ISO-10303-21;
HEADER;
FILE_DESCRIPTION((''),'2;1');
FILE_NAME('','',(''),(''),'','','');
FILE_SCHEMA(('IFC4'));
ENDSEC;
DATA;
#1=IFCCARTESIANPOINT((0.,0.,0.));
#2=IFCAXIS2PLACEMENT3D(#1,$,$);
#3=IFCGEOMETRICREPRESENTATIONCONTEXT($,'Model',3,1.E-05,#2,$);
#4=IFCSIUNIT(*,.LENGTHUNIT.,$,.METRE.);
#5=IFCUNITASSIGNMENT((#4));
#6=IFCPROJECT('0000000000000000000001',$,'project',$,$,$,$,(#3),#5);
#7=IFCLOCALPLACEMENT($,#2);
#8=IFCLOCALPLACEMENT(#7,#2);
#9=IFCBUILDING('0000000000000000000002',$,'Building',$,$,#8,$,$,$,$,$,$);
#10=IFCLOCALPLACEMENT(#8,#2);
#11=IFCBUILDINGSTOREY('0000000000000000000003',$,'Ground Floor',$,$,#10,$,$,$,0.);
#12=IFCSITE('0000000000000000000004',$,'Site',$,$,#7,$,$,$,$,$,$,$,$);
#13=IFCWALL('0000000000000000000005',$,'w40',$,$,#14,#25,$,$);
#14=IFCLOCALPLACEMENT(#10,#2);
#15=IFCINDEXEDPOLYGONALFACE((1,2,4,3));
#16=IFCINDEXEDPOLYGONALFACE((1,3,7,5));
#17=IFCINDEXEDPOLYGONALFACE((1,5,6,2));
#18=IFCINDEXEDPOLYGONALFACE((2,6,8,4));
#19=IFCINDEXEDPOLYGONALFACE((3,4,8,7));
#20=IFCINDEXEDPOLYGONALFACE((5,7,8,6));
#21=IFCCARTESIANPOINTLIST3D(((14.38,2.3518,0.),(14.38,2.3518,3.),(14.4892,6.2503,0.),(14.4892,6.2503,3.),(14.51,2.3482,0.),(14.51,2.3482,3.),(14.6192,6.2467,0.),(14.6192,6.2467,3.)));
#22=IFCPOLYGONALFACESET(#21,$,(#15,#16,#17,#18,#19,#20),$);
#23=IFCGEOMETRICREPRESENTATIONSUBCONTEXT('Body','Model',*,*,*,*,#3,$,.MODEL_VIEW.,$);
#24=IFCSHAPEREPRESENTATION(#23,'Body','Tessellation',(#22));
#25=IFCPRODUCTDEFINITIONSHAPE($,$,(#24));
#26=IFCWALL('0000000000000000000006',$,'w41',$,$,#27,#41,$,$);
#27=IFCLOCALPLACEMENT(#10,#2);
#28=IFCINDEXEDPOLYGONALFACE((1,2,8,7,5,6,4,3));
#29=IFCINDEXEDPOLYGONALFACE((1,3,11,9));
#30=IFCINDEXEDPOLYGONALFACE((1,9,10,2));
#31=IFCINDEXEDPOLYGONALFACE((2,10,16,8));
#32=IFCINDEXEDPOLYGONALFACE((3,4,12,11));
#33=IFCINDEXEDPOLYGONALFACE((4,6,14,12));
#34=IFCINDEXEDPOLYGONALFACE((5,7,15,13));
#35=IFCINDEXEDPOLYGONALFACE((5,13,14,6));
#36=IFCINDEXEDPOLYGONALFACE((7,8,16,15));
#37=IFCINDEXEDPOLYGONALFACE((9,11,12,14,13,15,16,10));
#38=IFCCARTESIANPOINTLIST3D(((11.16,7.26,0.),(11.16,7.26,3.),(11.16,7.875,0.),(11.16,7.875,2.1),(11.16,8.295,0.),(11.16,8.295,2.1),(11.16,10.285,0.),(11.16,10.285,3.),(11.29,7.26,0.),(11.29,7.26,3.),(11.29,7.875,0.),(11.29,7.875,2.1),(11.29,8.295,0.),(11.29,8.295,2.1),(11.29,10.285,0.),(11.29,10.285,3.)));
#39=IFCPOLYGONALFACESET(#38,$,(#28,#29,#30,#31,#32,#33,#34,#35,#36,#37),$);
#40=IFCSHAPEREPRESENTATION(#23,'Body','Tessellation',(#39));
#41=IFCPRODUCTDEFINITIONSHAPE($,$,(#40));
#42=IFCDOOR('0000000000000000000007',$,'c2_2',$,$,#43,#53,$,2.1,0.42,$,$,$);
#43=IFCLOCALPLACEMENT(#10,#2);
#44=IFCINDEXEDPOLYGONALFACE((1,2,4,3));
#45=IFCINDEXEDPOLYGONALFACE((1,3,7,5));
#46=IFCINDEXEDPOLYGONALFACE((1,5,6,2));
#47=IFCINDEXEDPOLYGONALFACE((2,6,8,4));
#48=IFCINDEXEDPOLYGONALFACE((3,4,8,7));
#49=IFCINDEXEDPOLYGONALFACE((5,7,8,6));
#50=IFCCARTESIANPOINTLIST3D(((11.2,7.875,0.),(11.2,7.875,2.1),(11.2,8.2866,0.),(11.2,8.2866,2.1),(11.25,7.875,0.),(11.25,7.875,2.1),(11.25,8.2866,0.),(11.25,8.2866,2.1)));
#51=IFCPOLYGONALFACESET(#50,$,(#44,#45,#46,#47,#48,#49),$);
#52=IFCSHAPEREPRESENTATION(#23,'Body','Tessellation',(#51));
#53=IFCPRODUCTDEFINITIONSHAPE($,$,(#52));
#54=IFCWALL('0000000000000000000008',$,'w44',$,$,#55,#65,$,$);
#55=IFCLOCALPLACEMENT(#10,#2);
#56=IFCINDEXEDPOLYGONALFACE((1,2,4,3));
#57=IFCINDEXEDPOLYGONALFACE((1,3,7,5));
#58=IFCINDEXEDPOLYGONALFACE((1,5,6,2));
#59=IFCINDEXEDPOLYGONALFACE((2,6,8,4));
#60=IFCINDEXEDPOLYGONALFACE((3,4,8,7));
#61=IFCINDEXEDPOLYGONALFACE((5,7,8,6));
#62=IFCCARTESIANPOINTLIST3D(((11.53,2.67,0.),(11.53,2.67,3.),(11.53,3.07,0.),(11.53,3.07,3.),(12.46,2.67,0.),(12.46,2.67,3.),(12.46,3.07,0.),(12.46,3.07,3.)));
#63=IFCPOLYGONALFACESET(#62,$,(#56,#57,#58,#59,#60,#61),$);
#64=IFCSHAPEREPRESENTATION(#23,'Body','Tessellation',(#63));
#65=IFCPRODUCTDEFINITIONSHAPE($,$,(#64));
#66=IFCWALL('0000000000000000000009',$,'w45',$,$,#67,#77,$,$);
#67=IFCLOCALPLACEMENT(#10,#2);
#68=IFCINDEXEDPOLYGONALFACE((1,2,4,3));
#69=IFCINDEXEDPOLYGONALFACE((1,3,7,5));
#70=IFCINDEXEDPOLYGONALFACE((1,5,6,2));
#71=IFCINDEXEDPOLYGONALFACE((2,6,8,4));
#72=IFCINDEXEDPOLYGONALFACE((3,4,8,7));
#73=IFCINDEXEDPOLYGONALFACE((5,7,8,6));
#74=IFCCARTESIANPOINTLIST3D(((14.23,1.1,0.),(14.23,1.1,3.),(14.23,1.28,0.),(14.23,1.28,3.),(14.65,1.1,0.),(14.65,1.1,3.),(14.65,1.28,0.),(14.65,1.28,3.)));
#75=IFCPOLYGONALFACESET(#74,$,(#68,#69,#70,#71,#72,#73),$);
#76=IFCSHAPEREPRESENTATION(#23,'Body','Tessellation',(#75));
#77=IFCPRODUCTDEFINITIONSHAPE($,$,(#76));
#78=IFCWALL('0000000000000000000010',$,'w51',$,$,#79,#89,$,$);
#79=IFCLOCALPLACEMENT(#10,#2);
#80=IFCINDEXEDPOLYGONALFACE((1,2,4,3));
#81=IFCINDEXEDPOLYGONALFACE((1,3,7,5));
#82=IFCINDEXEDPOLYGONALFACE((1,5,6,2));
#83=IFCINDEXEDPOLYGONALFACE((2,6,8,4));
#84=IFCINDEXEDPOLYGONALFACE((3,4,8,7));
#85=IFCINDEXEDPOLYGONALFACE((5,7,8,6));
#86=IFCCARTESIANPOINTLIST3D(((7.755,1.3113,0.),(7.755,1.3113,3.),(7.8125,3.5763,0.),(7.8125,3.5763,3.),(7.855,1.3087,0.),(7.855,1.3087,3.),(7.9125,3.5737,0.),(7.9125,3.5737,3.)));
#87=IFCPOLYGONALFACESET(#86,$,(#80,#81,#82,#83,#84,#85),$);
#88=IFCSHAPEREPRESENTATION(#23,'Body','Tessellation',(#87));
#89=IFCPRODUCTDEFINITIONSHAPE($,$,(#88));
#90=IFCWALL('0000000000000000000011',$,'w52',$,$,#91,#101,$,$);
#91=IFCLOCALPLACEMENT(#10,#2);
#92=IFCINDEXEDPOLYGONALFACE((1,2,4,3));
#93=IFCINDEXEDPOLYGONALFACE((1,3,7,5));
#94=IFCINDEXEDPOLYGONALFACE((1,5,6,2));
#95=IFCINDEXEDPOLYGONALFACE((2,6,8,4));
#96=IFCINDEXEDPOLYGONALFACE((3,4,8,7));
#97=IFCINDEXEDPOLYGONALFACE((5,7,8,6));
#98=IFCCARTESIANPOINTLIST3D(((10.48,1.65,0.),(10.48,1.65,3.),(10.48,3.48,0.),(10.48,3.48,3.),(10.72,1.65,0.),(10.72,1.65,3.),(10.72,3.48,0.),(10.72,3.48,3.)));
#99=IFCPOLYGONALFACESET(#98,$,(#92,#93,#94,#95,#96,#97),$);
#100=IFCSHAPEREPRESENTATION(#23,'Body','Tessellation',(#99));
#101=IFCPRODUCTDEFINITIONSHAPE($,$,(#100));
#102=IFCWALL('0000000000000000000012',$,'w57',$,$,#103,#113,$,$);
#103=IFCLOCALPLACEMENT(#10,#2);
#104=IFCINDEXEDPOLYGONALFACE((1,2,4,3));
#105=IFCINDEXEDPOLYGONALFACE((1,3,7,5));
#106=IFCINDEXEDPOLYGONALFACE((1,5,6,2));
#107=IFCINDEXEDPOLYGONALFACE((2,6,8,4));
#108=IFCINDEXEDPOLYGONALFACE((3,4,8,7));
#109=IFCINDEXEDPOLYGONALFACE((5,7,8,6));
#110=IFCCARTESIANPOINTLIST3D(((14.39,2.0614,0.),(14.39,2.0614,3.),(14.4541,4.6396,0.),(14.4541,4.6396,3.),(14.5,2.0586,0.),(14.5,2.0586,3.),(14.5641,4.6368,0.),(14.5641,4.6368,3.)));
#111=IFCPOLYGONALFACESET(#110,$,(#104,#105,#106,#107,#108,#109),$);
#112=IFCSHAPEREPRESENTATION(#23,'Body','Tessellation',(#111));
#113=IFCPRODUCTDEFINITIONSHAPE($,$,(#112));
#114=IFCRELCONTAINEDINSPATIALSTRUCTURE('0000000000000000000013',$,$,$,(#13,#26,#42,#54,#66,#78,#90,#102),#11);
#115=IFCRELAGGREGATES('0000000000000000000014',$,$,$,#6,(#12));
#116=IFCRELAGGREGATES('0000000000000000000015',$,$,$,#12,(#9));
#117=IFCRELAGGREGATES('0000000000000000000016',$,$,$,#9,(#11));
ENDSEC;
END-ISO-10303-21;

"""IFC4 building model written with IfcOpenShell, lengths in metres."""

from ifc_helpers import new_model, si_unit, frame, origin, place, context, subcontext, project, spatial, polyline, outline, extrude, element, fill, save


model = new_model("IFC4")

# Units and contexts
model_context = context("Model", 3, precision=1e-05, world=origin())
body_context = subcontext(model_context, "Body", "Model", "MODEL_VIEW")
ifc_project = project(units=[si_unit("LENGTHUNIT", "METRE")], contexts=[model_context])

# Site, building, storey
site_placement = place(None, origin())
site = spatial("IfcSite", under=ifc_project, at=site_placement, Name="Site")
building_placement = place(site_placement, origin())
building = spatial("IfcBuilding", under=site, at=building_placement, Name="Building")
storey_placement = place(building_placement, origin())
storey = spatial("IfcBuildingStorey", under=building, at=storey_placement, Name="Ground Floor", Elevation=0.0)

# Wall
wall_1_placement = place(storey_placement, frame((14.445, 2.35, 0.0), x_axis=(0.028003, 0.999608, 0.0)))
element("IfcWall", 1, at=wall_1_placement, inside=storey, Name="w40", context=body_context, shape_type="SweptSolid", body=[
    extrude(outline(polyline([(0.0, -0.065), (3.9, -0.065), (3.9, 0.065), (0.0, 0.065), (0.0, -0.065)])), origin(), (0.0, 0.0, 1.0), 3.0),
])

# Wall, opening, door
wall_2_placement = place(storey_placement, frame((11.225, 7.26, 0.0), x_axis=(0.0, 1.0, 0.0)))
wall_2 = element("IfcWall", 2, at=wall_2_placement, inside=storey, Name="w41", context=body_context, shape_type="SweptSolid", body=[
    extrude(outline(polyline([(0.0, -0.065), (3.025, -0.065), (3.025, 0.065), (0.0, 0.065), (0.0, -0.065)])), origin(), (0.0, 0.0, 1.0), 3.0),
])
opening_1_placement = place(wall_2_placement, frame((0.615, 0.0, 0.0)))
opening_1 = element("IfcOpeningElement", 3, at=opening_1_placement, cuts=wall_2, context=body_context, shape_type="SweptSolid", body=[
    extrude(outline(polyline([(0.0, -0.0683), (0.42, -0.0683), (0.42, 0.0683), (0.0, 0.0683), (0.0, -0.0683)])), origin(), (0.0, 0.0, 1.0), 2.1),
])
door_placement = place(wall_2_placement, frame((0.615, 0.0, 0.0)))
door = element("IfcDoor", 4, at=door_placement, inside=storey, Name="c2_2", OverallHeight=2.1, OverallWidth=0.42, context=body_context, shape_type="SweptSolid", body=[
    extrude(outline(polyline([(0.0, -0.025), (0.4116, -0.025), (0.4116, 0.025), (0.0, 0.025), (0.0, -0.025)])), origin(), (0.0, 0.0, 1.0), 2.1),
])
fill(opening_1, door)

# Walls
wall_3_placement = place(storey_placement, frame((11.53, 2.87, 0.0), x_axis=(1.0, 0.0, 0.0)))
element("IfcWall", 5, at=wall_3_placement, inside=storey, Name="w44", context=body_context, shape_type="SweptSolid", body=[
    extrude(outline(polyline([(0.0, -0.2), (0.93, -0.2), (0.93, 0.2), (0.0, 0.2), (0.0, -0.2)])), origin(), (0.0, 0.0, 1.0), 3.0),
])
wall_4_placement = place(storey_placement, frame((14.23, 1.19, 0.0), x_axis=(1.0, 0.0, 0.0)))
element("IfcWall", 6, at=wall_4_placement, inside=storey, Name="w45", context=body_context, shape_type="SweptSolid", body=[
    extrude(outline(polyline([(0.0, -0.09), (0.42, -0.09), (0.42, 0.09), (0.0, 0.09), (0.0, -0.09)])), origin(), (0.0, 0.0, 1.0), 3.0),
])
wall_5_placement = place(storey_placement, frame((7.805, 1.31, 0.0), x_axis=(0.025377, 0.999678, 0.0)))
element("IfcWall", 7, at=wall_5_placement, inside=storey, Name="w51", context=body_context, shape_type="SweptSolid", body=[
    extrude(outline(polyline([(0.0, -0.05), (2.2657, -0.05), (2.2657, 0.05), (0.0, 0.05), (0.0, -0.05)])), origin(), (0.0, 0.0, 1.0), 3.0),
])
wall_6_placement = place(storey_placement, frame((10.6, 1.65, 0.0), x_axis=(0.0, 1.0, 0.0)))
element("IfcWall", 8, at=wall_6_placement, inside=storey, Name="w52", context=body_context, shape_type="SweptSolid", body=[
    extrude(outline(polyline([(0.0, -0.12), (1.83, -0.12), (1.83, 0.12), (0.0, 0.12), (0.0, -0.12)])), origin(), (0.0, 0.0, 1.0), 3.0),
])
wall_7_placement = place(storey_placement, frame((14.445, 2.06, 0.0), x_axis=(0.024855, 0.999691, 0.0)))
element("IfcWall", 9, at=wall_7_placement, inside=storey, Name="w57", context=body_context, shape_type="SweptSolid", body=[
    extrude(outline(polyline([(0.0, -0.055), (2.579, -0.055), (2.579, 0.055), (0.0, 0.055), (0.0, -0.055)])), origin(), (0.0, 0.0, 1.0), 3.0),
])

save(model, "model.ifc")
